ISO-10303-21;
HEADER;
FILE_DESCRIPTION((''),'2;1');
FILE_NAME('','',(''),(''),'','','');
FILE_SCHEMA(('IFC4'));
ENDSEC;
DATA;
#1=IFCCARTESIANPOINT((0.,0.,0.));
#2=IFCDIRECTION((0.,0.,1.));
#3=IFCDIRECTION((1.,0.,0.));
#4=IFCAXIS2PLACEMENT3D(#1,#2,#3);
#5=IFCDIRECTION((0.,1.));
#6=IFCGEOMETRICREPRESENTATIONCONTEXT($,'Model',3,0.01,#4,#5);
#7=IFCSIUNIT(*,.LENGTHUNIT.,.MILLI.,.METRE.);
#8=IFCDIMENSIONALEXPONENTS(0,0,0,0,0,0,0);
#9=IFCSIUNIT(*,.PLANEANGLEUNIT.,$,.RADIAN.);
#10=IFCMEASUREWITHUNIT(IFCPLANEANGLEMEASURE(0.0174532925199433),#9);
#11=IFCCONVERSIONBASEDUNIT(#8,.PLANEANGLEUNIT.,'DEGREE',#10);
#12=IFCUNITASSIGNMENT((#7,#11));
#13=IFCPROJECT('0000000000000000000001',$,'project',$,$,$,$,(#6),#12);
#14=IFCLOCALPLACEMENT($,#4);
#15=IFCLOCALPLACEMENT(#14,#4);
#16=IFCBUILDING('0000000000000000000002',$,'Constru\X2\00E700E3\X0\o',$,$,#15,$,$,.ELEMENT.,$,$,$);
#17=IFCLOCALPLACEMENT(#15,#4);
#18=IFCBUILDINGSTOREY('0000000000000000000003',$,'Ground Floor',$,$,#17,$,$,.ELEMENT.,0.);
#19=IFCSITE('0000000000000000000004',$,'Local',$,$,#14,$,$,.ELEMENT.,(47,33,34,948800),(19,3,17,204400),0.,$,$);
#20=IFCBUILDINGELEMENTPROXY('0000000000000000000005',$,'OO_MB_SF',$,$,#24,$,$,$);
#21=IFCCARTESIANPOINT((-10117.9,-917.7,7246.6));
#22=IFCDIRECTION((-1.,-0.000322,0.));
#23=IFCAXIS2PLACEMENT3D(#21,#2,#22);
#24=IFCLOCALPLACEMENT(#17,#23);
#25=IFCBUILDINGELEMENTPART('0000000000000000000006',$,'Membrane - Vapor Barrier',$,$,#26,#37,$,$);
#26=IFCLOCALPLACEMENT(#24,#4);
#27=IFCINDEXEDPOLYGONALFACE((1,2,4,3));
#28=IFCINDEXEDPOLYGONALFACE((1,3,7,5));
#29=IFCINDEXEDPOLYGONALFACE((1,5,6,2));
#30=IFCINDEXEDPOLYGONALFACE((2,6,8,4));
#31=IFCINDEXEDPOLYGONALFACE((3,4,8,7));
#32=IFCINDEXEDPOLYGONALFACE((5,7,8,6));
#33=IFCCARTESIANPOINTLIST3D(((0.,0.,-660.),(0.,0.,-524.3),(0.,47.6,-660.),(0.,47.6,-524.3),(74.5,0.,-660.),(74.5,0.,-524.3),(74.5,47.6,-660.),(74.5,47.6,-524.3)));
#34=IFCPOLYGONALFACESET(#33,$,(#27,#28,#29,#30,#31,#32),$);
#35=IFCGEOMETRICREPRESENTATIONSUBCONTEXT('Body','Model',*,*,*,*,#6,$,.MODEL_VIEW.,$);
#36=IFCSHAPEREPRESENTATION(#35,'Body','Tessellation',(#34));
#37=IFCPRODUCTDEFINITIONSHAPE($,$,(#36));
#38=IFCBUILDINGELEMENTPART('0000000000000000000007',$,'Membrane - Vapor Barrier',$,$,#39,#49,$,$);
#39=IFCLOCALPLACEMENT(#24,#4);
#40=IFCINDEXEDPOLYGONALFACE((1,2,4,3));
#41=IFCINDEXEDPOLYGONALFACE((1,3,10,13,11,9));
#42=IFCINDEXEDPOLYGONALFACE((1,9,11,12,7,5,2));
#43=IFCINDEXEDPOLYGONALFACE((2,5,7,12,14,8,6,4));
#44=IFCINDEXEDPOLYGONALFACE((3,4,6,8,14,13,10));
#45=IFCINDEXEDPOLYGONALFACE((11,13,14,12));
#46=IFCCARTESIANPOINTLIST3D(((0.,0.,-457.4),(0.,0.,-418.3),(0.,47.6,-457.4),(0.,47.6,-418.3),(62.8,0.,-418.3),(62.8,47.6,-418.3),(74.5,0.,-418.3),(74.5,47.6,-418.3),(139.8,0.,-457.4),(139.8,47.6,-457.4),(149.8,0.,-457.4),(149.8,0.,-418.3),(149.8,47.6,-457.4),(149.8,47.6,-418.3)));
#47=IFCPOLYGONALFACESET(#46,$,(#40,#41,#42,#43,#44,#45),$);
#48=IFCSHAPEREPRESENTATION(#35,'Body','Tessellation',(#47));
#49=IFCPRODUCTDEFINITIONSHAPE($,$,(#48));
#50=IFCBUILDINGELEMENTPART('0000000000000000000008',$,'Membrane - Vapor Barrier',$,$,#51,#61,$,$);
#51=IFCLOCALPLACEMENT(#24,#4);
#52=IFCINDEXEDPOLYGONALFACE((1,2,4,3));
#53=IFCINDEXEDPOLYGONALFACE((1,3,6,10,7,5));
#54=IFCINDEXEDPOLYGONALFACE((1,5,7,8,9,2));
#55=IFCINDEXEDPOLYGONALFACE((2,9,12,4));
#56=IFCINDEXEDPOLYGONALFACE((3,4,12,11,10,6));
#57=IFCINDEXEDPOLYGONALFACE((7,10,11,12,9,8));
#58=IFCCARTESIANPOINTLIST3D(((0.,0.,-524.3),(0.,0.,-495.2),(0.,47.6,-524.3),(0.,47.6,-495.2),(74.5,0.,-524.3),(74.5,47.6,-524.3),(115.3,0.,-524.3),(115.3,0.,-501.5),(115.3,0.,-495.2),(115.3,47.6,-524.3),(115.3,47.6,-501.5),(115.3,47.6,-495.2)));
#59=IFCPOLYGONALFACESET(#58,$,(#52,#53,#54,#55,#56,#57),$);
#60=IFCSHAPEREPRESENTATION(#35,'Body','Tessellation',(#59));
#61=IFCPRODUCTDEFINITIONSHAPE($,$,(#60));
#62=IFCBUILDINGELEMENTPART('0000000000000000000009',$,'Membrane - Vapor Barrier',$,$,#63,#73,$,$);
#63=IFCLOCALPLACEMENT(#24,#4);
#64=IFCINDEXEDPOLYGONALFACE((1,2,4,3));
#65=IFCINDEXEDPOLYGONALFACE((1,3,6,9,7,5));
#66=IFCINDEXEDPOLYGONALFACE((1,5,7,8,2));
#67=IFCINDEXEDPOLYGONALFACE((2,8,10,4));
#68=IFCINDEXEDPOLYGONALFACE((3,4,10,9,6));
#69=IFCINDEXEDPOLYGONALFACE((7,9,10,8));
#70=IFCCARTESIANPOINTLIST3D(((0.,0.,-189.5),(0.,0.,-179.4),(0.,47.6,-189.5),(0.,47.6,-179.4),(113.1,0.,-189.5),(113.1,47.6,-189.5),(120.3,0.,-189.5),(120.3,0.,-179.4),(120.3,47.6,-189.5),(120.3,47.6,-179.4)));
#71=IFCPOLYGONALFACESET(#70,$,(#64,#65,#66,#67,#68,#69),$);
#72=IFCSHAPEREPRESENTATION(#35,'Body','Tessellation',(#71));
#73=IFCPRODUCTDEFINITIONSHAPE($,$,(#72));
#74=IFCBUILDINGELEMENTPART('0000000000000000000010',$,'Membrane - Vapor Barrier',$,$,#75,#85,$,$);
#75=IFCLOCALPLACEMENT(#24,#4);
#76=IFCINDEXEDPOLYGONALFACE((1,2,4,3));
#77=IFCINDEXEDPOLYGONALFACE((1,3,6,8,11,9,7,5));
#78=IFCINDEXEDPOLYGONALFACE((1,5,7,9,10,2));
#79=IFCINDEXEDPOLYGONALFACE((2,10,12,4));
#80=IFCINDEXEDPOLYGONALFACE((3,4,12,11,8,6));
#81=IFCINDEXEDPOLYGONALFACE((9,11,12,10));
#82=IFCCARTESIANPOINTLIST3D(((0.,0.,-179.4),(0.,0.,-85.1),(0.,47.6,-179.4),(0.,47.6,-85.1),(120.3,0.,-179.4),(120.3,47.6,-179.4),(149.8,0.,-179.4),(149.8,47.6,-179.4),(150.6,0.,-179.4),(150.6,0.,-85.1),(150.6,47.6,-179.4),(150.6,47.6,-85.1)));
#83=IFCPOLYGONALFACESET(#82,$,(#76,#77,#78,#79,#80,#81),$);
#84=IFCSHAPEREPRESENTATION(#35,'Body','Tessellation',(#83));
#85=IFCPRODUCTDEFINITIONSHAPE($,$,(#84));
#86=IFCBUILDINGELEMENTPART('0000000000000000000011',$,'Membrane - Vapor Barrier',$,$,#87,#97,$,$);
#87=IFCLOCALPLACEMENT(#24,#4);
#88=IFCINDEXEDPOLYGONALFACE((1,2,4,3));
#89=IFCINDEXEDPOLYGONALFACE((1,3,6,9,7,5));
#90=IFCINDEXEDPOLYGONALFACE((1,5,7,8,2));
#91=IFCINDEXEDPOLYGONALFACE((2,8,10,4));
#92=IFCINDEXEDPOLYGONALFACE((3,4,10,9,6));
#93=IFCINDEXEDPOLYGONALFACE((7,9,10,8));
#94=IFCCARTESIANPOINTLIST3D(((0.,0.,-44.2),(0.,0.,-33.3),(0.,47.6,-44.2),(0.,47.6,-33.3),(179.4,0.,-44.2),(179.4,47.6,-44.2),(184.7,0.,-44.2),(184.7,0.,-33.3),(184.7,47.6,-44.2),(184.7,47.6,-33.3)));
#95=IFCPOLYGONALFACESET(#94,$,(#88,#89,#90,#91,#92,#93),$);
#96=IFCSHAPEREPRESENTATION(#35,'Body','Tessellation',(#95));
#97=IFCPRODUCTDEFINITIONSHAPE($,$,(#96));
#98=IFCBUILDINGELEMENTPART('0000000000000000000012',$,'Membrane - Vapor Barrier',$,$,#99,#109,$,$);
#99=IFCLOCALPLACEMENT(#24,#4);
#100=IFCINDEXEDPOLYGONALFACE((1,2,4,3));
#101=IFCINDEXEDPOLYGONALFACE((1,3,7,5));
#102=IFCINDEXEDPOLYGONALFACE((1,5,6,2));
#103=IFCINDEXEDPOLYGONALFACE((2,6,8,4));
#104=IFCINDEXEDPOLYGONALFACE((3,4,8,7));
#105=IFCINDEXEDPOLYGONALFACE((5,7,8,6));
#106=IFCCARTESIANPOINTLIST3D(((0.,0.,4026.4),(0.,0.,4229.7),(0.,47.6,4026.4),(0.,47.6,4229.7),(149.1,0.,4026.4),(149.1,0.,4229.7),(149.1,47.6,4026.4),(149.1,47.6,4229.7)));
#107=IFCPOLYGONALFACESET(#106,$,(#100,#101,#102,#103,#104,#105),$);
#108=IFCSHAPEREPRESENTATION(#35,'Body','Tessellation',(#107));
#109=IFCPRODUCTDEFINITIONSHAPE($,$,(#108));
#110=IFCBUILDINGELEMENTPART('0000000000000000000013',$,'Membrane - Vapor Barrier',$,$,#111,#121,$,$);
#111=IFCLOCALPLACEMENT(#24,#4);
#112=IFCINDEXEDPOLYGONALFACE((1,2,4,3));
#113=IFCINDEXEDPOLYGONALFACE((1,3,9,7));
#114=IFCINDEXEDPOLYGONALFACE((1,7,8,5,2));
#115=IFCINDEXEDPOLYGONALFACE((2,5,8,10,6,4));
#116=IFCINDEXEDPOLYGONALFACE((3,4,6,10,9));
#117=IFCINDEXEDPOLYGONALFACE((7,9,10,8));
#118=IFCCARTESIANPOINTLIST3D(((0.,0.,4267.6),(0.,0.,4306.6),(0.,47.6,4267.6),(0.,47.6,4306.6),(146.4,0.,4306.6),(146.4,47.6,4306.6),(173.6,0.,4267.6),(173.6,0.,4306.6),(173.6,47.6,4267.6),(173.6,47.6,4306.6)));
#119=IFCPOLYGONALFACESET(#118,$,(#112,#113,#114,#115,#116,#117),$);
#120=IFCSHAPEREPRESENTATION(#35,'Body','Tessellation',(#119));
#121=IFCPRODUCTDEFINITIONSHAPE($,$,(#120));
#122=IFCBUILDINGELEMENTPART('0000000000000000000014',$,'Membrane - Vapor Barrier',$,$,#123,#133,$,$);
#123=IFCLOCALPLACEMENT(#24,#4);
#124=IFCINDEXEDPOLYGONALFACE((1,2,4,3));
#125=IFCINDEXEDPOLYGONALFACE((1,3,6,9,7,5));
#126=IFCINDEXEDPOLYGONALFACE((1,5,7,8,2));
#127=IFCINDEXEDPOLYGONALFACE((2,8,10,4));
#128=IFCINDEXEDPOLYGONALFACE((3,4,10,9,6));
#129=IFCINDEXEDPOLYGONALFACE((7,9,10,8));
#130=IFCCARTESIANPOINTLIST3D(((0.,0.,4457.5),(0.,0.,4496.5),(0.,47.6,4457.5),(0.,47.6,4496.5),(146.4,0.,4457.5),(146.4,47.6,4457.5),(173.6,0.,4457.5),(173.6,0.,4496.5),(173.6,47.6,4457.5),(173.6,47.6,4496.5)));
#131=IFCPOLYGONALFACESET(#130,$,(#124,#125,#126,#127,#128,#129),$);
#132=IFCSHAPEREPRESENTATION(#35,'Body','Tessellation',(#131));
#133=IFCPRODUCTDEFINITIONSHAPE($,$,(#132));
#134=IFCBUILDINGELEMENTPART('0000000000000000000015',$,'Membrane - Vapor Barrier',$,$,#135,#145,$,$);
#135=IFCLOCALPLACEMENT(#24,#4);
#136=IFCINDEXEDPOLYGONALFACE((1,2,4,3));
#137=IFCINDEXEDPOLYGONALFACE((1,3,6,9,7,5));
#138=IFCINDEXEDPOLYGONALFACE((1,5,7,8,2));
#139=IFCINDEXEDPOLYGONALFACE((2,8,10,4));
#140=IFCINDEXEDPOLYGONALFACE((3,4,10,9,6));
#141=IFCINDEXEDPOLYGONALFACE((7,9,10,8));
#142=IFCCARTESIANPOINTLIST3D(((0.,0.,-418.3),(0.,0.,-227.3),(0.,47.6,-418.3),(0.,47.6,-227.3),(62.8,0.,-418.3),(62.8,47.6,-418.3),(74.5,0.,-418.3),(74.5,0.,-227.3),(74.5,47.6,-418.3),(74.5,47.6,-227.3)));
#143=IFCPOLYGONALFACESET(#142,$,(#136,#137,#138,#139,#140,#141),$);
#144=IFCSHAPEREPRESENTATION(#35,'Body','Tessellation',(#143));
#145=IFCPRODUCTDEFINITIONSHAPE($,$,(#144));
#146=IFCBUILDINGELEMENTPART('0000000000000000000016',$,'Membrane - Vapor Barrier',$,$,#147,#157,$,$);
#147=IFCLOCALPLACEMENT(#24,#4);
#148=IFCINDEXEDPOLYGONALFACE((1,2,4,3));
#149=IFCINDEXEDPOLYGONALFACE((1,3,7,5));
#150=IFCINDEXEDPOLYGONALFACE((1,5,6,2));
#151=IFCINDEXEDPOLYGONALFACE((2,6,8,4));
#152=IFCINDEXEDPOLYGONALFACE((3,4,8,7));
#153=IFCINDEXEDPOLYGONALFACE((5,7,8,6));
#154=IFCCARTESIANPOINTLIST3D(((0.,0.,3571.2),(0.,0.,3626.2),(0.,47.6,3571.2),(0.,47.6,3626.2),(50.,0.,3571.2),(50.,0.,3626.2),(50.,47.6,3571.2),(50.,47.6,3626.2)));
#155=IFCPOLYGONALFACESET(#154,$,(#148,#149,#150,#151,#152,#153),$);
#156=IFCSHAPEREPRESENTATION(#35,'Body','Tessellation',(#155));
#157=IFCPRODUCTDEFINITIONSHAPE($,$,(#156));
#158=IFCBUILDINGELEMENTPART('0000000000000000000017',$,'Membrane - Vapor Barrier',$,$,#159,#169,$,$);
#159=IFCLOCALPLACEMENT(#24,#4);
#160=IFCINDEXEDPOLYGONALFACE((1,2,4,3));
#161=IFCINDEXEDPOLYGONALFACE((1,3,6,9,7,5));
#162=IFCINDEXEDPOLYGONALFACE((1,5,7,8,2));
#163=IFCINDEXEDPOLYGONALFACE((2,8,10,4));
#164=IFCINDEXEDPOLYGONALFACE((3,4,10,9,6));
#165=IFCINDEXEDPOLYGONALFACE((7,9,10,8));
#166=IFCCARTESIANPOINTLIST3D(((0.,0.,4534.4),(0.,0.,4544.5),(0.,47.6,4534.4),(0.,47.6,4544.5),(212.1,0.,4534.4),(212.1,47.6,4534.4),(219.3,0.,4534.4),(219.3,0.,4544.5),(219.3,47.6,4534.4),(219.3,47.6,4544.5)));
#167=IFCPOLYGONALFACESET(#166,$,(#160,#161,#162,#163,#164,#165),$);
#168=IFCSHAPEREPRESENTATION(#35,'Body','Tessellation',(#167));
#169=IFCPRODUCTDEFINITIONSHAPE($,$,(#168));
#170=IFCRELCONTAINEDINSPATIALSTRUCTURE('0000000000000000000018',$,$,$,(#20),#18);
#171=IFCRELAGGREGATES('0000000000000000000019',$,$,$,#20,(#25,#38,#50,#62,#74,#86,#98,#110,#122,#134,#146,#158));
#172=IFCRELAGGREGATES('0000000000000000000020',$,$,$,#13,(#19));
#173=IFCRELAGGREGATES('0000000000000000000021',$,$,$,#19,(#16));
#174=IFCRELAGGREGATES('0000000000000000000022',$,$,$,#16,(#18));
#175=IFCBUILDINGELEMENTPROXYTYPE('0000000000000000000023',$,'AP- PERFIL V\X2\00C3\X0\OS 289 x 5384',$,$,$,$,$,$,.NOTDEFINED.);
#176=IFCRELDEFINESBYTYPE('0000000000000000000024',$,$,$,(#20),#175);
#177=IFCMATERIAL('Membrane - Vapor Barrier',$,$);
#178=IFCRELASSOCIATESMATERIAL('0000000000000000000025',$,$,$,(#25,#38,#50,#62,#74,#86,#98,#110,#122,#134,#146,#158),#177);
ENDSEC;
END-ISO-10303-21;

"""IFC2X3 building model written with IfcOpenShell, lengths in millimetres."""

from ifc_helpers import new_model, entity, si_unit, converted_unit, direction, frame, origin_with_axes, place, context, subcontext, project, spatial, polyline, outline, extrude, material, type_object, element, aggregate, save


model = new_model("IFC2X3")

# Units and contexts
model_context = context("Model", 3, precision=0.01, world=origin_with_axes(), true_north=direction((0.0, 1.0)))
body_context = subcontext(model_context, "Body", "Model", "MODEL_VIEW")
ifc_project = project(units=[si_unit("LENGTHUNIT", "METRE", prefix="MILLI"), converted_unit("PLANEANGLEUNIT", "DEGREE", entity("IfcPlaneAngleMeasure", 0.0174532925199433), si_unit("PLANEANGLEUNIT", "RADIAN"), dimensions=[0, 0, 0, 0, 0, 0, 0])], contexts=[model_context])

# Site, building, storey
site_placement = place(None, origin_with_axes())
site = spatial("IfcSite", under=ifc_project, at=site_placement, Name="Local", CompositionType="ELEMENT", RefLatitude=(47, 33, 34, 948800), RefLongitude=(19, 3, 17, 204400), RefElevation=0.0)
building_placement = place(site_placement, origin_with_axes())
building = spatial("IfcBuilding", under=site, at=building_placement, Name="Construção", CompositionType="ELEMENT")
storey_placement = place(building_placement, origin_with_axes())
storey = spatial("IfcBuildingStorey", under=building, at=storey_placement, Name="Ground Floor", CompositionType="ELEMENT", Elevation=0.0)

# Shared definitions
ifc_material = material(Name="Membrane - Vapor Barrier")

# Building element proxy, building element parts
building_element_proxy_type = type_object("IfcBuildingElementProxyType", Name="AP- PERFIL VÃOS 289 x 5384", PredefinedType="NOTDEFINED")
proxy_1_placement = place(storey_placement, frame((-10117.9, -917.7, 7246.6), z_axis=(0.0, 0.0, 1.0), x_axis=(-1.0, -0.000322, 0.0)))
proxy_1 = element("IfcBuildingElementProxy", 1, at=proxy_1_placement, inside=storey, type_object=building_element_proxy_type, Name="OO_MB_SF")
building_element_part_1_placement = place(proxy_1_placement, origin_with_axes())
building_element_part_1 = element("IfcBuildingElementPart", 2, at=building_element_part_1_placement, material=ifc_material, Name="Membrane - Vapor Barrier", context=body_context, shape_type="SweptSolid", body=[
    extrude(outline(polyline([(0.0, -660.0), (74.5, -660.0), (74.5, -524.3), (0.0, -524.3), (0.0, -660.0)])), frame((0.0, 47.6, 0.0), z_axis=(0.0, -1.0, 0.0), x_axis=(1.0, 0.0, 0.0)), (0.0, 0.0, 1.0), 47.6),
])
building_element_part_2_placement = place(proxy_1_placement, origin_with_axes())
building_element_part_2 = element("IfcBuildingElementPart", 3, at=building_element_part_2_placement, material=ifc_material, Name="Membrane - Vapor Barrier", context=body_context, shape_type="SweptSolid", body=[
    extrude(outline(polyline([(62.8, -418.3), (0.0, -418.3), (0.0, -457.4), (139.8, -457.4), (149.8, -457.4), (149.8, -418.3), (74.5, -418.3), (62.8, -418.3)])), frame((0.0, 47.6, 0.0), z_axis=(0.0, -1.0, 0.0), x_axis=(1.0, 0.0, 0.0)), (0.0, 0.0, 1.0), 47.6),
])
building_element_part_3_placement = place(proxy_1_placement, origin_with_axes())
building_element_part_3 = element("IfcBuildingElementPart", 4, at=building_element_part_3_placement, material=ifc_material, Name="Membrane - Vapor Barrier", context=body_context, shape_type="SweptSolid", body=[
    extrude(outline(polyline([(0.0, -524.3), (74.5, -524.3), (115.3, -524.3), (115.3, -501.5), (115.3, -495.2), (0.0, -495.2), (0.0, -524.3)])), frame((0.0, 47.6, 0.0), z_axis=(0.0, -1.0, 0.0), x_axis=(1.0, 0.0, 0.0)), (0.0, 0.0, 1.0), 47.6),
])
building_element_part_4_placement = place(proxy_1_placement, origin_with_axes())
building_element_part_4 = element("IfcBuildingElementPart", 5, at=building_element_part_4_placement, material=ifc_material, Name="Membrane - Vapor Barrier", context=body_context, shape_type="SweptSolid", body=[
    extrude(outline(polyline([(120.3, -179.4), (0.0, -179.4), (0.0, -189.5), (113.1, -189.5), (120.3, -189.5), (120.3, -179.4)])), frame((0.0, 47.6, 0.0), z_axis=(0.0, -1.0, 0.0), x_axis=(1.0, 0.0, 0.0)), (0.0, 0.0, 1.0), 47.6),
])
building_element_part_5_placement = place(proxy_1_placement, origin_with_axes())
building_element_part_5 = element("IfcBuildingElementPart", 6, at=building_element_part_5_placement, material=ifc_material, Name="Membrane - Vapor Barrier", context=body_context, shape_type="SweptSolid", body=[
    extrude(outline(polyline([(0.0, -85.1), (0.0, -179.4), (120.3, -179.4), (149.8, -179.4), (150.6, -179.4), (150.6, -85.1), (0.0, -85.1)])), frame((0.0, 47.6, 0.0), z_axis=(0.0, -1.0, 0.0), x_axis=(1.0, 0.0, 0.0)), (0.0, 0.0, 1.0), 47.6),
])
building_element_part_6_placement = place(proxy_1_placement, origin_with_axes())
building_element_part_6 = element("IfcBuildingElementPart", 7, at=building_element_part_6_placement, material=ifc_material, Name="Membrane - Vapor Barrier", context=body_context, shape_type="SweptSolid", body=[
    extrude(outline(polyline([(184.7, -33.3), (0.0, -33.3), (0.0, -44.2), (179.4, -44.2), (184.7, -44.2), (184.7, -33.3)])), frame((0.0, 47.6, 0.0), z_axis=(0.0, -1.0, 0.0), x_axis=(1.0, 0.0, 0.0)), (0.0, 0.0, 1.0), 47.6),
])
building_element_part_7_placement = place(proxy_1_placement, origin_with_axes())
building_element_part_7 = element("IfcBuildingElementPart", 8, at=building_element_part_7_placement, material=ifc_material, Name="Membrane - Vapor Barrier", context=body_context, shape_type="SweptSolid", body=[
    extrude(outline(polyline([(149.1, 4229.7), (0.0, 4229.7), (0.0, 4026.4), (149.1, 4026.4), (149.1, 4229.7)])), frame((0.0, 47.6, 0.0), z_axis=(0.0, -1.0, 0.0), x_axis=(1.0, 0.0, 0.0)), (0.0, 0.0, 1.0), 47.6),
])
building_element_part_8_placement = place(proxy_1_placement, origin_with_axes())
building_element_part_8 = element("IfcBuildingElementPart", 9, at=building_element_part_8_placement, material=ifc_material, Name="Membrane - Vapor Barrier", context=body_context, shape_type="SweptSolid", body=[
    extrude(outline(polyline([(0.0, 4306.6), (0.0, 4267.6), (173.6, 4267.6), (173.6, 4306.6), (146.4, 4306.6), (0.0, 4306.6)])), frame((0.0, 47.6, 0.0), z_axis=(0.0, -1.0, 0.0), x_axis=(1.0, 0.0, 0.0)), (0.0, 0.0, 1.0), 47.6),
])
building_element_part_9_placement = place(proxy_1_placement, origin_with_axes())
building_element_part_9 = element("IfcBuildingElementPart", 10, at=building_element_part_9_placement, material=ifc_material, Name="Membrane - Vapor Barrier", context=body_context, shape_type="SweptSolid", body=[
    extrude(outline(polyline([(173.6, 4496.5), (0.0, 4496.5), (0.0, 4457.5), (146.4, 4457.5), (173.6, 4457.5), (173.6, 4496.5)])), frame((0.0, 47.6, 0.0), z_axis=(0.0, -1.0, 0.0), x_axis=(1.0, 0.0, 0.0)), (0.0, 0.0, 1.0), 47.6),
])
building_element_part_10_placement = place(proxy_1_placement, origin_with_axes())
building_element_part_10 = element("IfcBuildingElementPart", 11, at=building_element_part_10_placement, material=ifc_material, Name="Membrane - Vapor Barrier", context=body_context, shape_type="SweptSolid", body=[
    extrude(outline(polyline([(0.0, -227.3), (0.0, -418.3), (62.8, -418.3), (74.5, -418.3), (74.5, -227.3), (0.0, -227.3)])), frame((0.0, 47.6, 0.0), z_axis=(0.0, -1.0, 0.0), x_axis=(1.0, 0.0, 0.0)), (0.0, 0.0, 1.0), 47.6),
])
building_element_part_11_placement = place(proxy_1_placement, origin_with_axes())
building_element_part_11 = element("IfcBuildingElementPart", 12, at=building_element_part_11_placement, material=ifc_material, Name="Membrane - Vapor Barrier", context=body_context, shape_type="SweptSolid", body=[
    extrude(outline(polyline([(0.0, 3571.2), (50.0, 3571.2), (50.0, 3626.2), (0.0, 3626.2), (0.0, 3571.2)])), frame((0.0, 47.6, 0.0), z_axis=(0.0, -1.0, 0.0), x_axis=(1.0, 0.0, 0.0)), (0.0, 0.0, 1.0), 47.6),
])
building_element_part_12_placement = place(proxy_1_placement, origin_with_axes())
building_element_part_12 = element("IfcBuildingElementPart", 13, at=building_element_part_12_placement, material=ifc_material, Name="Membrane - Vapor Barrier", context=body_context, shape_type="SweptSolid", body=[
    extrude(outline(polyline([(0.0, 4534.4), (212.1, 4534.4), (219.3, 4534.4), (219.3, 4544.5), (0.0, 4544.5), (0.0, 4534.4)])), frame((0.0, 47.6, 0.0), z_axis=(0.0, -1.0, 0.0), x_axis=(1.0, 0.0, 0.0)), (0.0, 0.0, 1.0), 47.6),
])
aggregate(proxy_1, [building_element_part_1, building_element_part_2, building_element_part_3, building_element_part_4, building_element_part_5, building_element_part_6, building_element_part_7, building_element_part_8, building_element_part_9, building_element_part_10, building_element_part_11, building_element_part_12])

save(model, "model.ifc")
